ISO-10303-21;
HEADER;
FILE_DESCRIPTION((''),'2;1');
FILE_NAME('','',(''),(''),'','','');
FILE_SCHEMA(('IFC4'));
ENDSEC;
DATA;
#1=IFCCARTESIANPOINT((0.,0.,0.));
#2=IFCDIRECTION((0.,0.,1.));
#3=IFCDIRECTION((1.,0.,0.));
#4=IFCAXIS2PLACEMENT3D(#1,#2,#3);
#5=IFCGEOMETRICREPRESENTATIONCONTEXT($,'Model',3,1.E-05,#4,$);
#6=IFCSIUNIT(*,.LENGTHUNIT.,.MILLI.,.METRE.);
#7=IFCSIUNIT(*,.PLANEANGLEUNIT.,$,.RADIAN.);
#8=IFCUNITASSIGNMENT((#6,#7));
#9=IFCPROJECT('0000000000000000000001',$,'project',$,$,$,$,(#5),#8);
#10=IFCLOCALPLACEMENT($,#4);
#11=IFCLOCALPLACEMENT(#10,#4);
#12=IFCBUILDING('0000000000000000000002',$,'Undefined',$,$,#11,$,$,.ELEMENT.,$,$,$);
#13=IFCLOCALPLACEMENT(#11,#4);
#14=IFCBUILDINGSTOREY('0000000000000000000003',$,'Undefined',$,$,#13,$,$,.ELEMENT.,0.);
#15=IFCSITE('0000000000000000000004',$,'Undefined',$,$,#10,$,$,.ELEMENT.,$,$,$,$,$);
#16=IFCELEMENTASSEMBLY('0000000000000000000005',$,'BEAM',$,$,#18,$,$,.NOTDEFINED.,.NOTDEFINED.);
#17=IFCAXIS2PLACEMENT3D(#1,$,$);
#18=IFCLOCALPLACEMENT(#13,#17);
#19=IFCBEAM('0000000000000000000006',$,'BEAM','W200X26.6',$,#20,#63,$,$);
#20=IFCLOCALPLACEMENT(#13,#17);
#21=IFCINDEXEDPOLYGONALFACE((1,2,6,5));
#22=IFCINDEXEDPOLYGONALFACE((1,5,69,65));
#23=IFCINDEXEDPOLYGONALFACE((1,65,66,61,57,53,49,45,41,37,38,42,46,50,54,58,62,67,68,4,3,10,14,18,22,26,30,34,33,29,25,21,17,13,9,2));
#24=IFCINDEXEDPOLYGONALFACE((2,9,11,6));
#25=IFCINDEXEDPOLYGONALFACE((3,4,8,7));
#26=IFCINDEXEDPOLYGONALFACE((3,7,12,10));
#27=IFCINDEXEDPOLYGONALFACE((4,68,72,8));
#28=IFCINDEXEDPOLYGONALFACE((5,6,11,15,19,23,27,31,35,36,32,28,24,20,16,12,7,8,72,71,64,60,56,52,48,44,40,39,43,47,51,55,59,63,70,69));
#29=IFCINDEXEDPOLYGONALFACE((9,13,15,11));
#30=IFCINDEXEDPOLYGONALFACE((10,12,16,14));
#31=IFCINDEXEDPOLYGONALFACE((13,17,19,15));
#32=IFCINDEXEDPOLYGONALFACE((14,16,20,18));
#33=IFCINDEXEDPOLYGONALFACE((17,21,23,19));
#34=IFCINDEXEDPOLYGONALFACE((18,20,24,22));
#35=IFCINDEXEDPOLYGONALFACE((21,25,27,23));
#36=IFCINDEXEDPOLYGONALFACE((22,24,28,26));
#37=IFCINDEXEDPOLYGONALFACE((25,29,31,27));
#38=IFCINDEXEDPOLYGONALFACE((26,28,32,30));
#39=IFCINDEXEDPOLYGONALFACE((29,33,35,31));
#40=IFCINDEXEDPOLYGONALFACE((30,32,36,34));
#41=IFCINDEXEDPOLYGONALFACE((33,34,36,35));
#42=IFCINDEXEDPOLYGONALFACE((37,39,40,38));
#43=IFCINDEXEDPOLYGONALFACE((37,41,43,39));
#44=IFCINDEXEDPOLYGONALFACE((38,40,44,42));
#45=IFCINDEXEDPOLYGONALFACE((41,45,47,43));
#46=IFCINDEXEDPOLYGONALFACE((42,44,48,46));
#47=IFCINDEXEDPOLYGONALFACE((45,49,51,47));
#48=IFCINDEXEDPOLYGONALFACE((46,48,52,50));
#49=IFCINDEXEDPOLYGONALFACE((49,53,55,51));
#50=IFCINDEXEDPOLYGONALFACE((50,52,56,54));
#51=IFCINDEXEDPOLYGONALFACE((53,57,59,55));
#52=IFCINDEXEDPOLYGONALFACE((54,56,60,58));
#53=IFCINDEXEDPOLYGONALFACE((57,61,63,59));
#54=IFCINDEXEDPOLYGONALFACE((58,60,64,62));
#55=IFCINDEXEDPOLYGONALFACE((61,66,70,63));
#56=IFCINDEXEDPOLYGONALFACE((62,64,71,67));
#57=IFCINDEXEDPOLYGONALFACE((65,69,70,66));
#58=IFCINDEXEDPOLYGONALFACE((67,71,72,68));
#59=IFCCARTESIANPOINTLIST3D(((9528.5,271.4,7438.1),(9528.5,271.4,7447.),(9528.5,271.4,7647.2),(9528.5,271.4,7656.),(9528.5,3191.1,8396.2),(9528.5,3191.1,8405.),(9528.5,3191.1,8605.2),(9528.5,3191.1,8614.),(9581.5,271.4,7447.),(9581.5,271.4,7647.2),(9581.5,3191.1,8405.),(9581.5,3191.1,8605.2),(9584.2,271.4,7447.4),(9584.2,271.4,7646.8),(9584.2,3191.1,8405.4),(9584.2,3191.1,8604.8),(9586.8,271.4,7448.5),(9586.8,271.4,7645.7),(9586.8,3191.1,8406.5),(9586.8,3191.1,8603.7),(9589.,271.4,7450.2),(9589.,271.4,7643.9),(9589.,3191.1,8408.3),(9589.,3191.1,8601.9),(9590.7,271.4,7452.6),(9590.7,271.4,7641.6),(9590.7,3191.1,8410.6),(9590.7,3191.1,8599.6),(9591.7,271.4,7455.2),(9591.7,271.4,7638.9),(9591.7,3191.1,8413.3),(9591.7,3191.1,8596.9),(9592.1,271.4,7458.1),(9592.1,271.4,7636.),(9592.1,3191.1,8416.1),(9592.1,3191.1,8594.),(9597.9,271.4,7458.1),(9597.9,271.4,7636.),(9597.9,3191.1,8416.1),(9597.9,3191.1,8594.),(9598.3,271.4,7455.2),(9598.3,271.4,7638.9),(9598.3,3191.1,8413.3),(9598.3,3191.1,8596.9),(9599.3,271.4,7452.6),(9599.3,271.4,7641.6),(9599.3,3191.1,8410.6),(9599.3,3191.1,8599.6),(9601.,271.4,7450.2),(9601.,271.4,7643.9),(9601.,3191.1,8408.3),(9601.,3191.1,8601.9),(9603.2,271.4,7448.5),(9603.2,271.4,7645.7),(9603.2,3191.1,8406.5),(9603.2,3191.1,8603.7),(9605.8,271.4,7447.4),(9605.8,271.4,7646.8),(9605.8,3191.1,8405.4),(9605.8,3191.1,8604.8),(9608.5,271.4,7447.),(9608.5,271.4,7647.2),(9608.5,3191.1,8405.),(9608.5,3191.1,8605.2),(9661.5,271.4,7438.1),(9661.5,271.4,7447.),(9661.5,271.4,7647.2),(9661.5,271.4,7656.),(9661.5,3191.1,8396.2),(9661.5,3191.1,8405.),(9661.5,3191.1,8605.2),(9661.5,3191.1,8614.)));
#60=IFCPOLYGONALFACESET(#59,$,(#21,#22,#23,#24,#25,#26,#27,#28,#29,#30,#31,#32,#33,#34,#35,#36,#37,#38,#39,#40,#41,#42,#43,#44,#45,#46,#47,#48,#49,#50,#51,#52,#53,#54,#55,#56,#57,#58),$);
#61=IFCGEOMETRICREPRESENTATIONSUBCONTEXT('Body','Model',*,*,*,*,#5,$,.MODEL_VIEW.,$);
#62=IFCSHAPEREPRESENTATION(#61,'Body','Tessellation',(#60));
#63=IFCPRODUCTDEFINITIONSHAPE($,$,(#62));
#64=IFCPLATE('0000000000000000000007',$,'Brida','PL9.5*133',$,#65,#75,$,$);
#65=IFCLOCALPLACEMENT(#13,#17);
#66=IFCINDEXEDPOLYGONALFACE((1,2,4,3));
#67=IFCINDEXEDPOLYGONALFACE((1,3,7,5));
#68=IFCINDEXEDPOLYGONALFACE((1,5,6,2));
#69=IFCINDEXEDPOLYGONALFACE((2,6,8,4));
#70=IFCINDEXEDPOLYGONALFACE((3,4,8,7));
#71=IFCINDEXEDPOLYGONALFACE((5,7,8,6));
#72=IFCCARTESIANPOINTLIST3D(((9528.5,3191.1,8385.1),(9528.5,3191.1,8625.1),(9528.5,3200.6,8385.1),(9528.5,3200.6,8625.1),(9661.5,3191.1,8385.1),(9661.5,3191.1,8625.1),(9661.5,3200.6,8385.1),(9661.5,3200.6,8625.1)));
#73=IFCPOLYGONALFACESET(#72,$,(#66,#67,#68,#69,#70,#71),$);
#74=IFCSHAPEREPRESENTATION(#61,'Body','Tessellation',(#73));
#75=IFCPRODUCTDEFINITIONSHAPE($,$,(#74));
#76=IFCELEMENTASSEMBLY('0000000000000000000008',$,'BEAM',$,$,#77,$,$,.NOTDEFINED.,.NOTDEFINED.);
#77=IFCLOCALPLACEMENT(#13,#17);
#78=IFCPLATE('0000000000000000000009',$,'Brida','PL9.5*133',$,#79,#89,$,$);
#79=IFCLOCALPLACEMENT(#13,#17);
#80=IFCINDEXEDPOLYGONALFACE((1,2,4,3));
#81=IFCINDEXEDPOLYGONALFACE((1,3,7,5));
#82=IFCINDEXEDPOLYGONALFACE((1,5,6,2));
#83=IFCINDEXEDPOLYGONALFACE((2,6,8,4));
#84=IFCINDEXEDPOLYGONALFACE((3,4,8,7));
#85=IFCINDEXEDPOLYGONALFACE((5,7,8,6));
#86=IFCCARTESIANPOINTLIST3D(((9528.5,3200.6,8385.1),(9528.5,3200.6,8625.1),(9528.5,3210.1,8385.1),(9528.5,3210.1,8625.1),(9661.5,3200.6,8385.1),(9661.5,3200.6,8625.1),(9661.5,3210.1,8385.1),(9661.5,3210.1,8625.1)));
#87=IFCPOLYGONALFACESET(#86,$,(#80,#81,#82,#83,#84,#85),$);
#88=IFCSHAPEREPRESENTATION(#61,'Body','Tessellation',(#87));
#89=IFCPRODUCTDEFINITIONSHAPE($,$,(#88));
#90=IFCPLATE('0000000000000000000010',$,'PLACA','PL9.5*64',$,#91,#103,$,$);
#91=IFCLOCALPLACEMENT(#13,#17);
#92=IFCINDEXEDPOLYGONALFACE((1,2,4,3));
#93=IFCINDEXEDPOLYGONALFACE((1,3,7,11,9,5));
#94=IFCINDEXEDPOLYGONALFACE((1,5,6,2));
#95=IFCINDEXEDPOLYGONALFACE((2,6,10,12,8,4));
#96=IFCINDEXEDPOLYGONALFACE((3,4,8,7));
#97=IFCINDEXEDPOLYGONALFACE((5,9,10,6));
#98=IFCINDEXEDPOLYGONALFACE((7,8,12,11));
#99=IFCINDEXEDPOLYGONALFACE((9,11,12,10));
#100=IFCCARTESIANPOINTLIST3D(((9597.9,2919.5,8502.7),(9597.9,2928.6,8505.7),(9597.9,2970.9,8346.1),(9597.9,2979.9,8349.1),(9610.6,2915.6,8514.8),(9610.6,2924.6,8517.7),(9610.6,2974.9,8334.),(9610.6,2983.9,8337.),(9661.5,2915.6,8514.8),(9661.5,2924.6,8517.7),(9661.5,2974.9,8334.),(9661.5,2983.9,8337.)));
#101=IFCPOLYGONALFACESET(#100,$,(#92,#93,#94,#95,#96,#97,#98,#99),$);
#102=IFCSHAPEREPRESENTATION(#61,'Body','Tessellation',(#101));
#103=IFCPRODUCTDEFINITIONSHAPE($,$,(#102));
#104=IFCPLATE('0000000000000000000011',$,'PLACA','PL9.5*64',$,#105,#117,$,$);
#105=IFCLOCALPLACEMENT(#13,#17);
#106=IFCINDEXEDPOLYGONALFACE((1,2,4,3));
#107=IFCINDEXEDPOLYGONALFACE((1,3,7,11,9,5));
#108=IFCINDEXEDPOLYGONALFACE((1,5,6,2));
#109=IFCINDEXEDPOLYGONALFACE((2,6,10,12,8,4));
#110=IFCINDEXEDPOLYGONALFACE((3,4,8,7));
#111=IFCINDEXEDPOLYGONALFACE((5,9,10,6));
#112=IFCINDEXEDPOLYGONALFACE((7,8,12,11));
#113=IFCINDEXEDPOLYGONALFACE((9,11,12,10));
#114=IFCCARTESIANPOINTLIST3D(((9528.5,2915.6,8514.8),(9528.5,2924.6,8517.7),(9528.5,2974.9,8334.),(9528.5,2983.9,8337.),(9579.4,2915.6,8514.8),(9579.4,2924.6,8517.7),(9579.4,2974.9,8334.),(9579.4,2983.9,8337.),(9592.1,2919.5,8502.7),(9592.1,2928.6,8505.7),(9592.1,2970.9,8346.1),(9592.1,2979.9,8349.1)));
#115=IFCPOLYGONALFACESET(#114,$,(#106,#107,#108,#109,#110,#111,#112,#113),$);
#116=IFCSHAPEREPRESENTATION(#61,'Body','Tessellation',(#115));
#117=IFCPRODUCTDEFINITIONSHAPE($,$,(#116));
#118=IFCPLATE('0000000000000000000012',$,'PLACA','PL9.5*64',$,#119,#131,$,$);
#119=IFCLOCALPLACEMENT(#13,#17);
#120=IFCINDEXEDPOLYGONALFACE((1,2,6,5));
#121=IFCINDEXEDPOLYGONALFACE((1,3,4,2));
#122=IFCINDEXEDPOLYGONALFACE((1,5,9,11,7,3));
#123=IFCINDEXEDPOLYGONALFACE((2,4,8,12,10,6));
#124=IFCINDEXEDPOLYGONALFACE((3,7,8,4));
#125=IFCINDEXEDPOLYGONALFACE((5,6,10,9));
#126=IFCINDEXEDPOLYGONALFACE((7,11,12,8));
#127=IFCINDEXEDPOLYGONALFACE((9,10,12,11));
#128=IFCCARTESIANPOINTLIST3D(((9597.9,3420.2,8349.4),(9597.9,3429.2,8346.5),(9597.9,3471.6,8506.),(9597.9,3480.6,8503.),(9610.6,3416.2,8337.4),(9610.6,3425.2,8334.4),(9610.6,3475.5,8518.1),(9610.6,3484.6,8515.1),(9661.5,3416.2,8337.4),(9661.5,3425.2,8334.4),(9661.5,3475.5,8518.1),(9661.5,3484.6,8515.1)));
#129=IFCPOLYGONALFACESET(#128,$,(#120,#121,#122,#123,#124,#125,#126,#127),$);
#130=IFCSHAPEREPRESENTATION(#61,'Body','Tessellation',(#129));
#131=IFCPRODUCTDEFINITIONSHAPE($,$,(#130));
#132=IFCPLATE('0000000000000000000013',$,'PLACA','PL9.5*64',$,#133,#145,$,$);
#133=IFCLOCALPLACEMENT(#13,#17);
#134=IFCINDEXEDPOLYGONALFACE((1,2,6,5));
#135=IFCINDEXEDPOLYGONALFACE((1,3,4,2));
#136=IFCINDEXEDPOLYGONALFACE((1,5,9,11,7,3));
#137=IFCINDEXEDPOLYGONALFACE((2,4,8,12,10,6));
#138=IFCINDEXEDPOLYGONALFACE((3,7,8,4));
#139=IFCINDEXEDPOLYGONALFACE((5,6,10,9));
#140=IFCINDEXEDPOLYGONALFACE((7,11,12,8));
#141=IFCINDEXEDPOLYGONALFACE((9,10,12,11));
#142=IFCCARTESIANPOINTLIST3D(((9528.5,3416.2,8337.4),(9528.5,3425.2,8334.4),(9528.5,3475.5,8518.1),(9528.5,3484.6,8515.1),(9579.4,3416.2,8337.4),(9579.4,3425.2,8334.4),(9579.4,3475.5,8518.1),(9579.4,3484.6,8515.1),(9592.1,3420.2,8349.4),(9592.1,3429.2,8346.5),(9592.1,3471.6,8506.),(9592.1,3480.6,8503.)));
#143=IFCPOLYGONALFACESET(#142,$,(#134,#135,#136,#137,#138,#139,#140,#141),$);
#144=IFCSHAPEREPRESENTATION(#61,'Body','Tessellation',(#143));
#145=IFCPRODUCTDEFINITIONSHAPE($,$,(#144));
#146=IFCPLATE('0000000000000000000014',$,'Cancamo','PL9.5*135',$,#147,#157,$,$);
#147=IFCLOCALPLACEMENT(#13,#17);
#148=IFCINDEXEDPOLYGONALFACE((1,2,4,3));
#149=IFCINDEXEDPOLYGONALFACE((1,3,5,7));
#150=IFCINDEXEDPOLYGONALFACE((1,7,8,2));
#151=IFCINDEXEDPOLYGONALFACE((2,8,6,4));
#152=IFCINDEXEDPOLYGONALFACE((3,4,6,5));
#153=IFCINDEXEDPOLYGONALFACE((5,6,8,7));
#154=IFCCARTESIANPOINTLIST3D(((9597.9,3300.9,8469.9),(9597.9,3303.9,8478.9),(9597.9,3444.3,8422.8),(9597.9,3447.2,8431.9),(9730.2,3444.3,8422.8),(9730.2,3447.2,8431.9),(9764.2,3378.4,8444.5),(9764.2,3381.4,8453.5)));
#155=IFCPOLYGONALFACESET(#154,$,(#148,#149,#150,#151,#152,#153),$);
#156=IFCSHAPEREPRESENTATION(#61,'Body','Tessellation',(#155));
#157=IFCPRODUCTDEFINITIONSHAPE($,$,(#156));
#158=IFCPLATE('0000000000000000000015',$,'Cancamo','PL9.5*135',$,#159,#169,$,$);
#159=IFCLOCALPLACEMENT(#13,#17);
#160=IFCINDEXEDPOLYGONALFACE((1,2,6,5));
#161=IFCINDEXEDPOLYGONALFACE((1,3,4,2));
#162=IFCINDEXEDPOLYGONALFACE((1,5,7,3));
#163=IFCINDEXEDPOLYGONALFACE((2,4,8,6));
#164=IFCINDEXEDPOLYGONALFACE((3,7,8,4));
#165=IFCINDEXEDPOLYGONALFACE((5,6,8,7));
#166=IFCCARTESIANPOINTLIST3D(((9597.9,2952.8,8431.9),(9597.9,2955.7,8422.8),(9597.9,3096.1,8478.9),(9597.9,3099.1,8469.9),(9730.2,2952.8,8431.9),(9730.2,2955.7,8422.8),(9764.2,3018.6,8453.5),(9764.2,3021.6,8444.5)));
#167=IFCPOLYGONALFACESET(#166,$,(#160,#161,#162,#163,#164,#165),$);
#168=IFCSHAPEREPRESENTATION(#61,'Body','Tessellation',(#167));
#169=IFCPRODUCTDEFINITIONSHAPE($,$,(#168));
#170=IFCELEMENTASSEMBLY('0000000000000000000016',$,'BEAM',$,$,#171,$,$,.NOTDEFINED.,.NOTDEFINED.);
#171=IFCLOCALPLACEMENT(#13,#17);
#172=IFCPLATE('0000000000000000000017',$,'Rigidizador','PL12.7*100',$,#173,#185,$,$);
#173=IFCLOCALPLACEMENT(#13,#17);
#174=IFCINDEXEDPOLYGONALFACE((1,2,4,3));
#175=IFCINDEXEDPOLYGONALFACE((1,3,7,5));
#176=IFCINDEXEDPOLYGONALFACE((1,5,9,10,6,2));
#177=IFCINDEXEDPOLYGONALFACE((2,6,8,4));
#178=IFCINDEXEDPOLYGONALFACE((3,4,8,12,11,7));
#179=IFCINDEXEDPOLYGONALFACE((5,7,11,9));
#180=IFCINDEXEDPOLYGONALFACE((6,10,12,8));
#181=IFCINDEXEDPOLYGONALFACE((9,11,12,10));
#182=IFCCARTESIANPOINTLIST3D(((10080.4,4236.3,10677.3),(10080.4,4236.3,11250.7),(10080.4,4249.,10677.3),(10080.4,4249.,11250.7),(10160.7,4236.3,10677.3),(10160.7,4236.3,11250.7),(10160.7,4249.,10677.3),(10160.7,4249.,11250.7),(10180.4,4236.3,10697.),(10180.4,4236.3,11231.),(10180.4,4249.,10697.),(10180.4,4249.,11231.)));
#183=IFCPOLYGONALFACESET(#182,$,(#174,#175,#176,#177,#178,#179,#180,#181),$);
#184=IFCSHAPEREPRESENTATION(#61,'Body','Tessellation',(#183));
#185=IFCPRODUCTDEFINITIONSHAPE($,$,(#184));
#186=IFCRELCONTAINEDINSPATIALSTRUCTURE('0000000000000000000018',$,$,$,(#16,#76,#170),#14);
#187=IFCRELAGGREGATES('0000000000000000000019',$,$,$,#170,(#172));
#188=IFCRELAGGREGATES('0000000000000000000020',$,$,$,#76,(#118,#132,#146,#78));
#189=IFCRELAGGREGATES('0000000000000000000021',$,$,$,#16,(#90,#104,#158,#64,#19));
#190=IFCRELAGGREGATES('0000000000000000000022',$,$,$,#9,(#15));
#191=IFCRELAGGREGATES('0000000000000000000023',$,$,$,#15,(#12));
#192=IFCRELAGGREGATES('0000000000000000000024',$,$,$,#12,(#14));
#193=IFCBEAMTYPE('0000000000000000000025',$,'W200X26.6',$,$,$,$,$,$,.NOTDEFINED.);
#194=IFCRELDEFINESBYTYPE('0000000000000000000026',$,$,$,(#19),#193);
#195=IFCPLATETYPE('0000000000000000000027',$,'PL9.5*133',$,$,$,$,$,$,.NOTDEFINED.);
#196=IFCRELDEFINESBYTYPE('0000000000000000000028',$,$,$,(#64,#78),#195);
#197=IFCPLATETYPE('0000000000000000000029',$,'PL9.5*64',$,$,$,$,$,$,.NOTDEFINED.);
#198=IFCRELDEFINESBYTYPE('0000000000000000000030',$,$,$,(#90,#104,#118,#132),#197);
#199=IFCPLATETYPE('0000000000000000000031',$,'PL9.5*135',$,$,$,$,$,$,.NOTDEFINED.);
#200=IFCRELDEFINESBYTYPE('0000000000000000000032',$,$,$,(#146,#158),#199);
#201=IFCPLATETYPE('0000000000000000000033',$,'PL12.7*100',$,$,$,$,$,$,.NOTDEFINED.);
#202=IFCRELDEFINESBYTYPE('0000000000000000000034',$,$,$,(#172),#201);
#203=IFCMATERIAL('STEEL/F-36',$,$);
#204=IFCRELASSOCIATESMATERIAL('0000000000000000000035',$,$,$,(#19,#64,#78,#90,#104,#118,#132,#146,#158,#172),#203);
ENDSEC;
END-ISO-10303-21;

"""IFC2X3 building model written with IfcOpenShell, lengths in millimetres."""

from ifc_helpers import new_model, si_unit, frame, origin_with_axes, origin_2d_with_axis, place, context, subcontext, project, spatial, polyline, i_section, outline, extrude, clip, halfspace, material, type_object, element, aggregate, save


model = new_model("IFC2X3")

# Units and contexts
model_context = context("Model", 3, precision=1e-05, world=origin_with_axes())
body_context = subcontext(model_context, "Body", "Model", "MODEL_VIEW")
ifc_project = project(units=[si_unit("LENGTHUNIT", "METRE", prefix="MILLI"), si_unit("PLANEANGLEUNIT", "RADIAN")], contexts=[model_context])

# Site, building, storey
site_placement = place(None, origin_with_axes())
site = spatial("IfcSite", under=ifc_project, at=site_placement, Name="Undefined", CompositionType="ELEMENT")
building_placement = place(site_placement, origin_with_axes())
building = spatial("IfcBuilding", under=site, at=building_placement, Name="Undefined", CompositionType="ELEMENT")
storey_placement = place(building_placement, origin_with_axes())
storey = spatial("IfcBuildingStorey", under=building, at=storey_placement, Name="Undefined", CompositionType="ELEMENT", Elevation=0.0)

# Element assembly, beam, plate
assembly_1_placement = place(storey_placement, origin_with_axes())
assembly_1 = element("IfcElementAssembly", 1, at=assembly_1_placement, inside=storey, Name="BEAM", AssemblyPlace="NOTDEFINED", PredefinedType="NOTDEFINED")
ifc_material_1 = material(Name="STEEL/F-36")
beam_type_1 = type_object("IfcBeamType", Name="W200X26.6", PredefinedType="NOTDEFINED")
beam_1_placement = place(assembly_1_placement, frame((9595.0, 3232.7, 8518.7), z_axis=(0.0, -0.311771, 0.950157), x_axis=(0.0, -0.950157, -0.311771)))
beam_1 = element("IfcBeam", 2, at=beam_1_placement, type_object=beam_type_1, material=ifc_material_1, Name="BEAM", Description="W200X26.6", context=body_context, shape_type="Clipping", body=[
    clip(clip(extrude(i_section(OverallWidth=133.0, OverallDepth=207.0, WebThickness=5.8, FlangeThickness=8.4, FilletRadius=10.6, at=origin_2d_with_axis()), frame((3367.9, 0.0, 0.0), z_axis=(-1.0, 0.0, 0.0), x_axis=(0.0, -1.0, 0.0)), (0.0, 0.0, 1.0), 3392.7), halfspace(frame((3082.6, 0.0, 103.8), z_axis=(-0.950157, 0.0, -0.311771), x_axis=(0.311771, 0.0, -0.950157)), True)), halfspace(frame((8.8, 0.0, 106.5), z_axis=(-0.950152, 0.0, -0.311787), x_axis=(0.0, -1.0, 0.0)), False)),
])
plate_type_1 = type_object("IfcPlateType", Name="PL9.5*133", PredefinedType="NOTDEFINED")
plate_1_placement = place(assembly_1_placement, frame((9595.0, 3195.9, 8625.1), z_axis=(0.0, 1.0, -0.000017), x_axis=(0.0, -0.000017, -1.0)))
plate_1 = element("IfcPlate", 3, at=plate_1_placement, type_object=plate_type_1, material=ifc_material_1, Name="Brida", Description="PL9.5*133", context=body_context, shape_type="SweptSolid", body=[
    extrude(outline(polyline([(0.0, -66.5), (0.0, 66.5), (240.0, 66.5), (240.0, -66.5), (0.0, -66.5)])), frame((0.0, 0.0, -4.8), z_axis=(0.0, 0.0, 1.0), x_axis=(1.0, 0.0, 0.0)), (0.0, 0.0, 1.0), 9.5),
])

# Element assembly, plate
assembly_2_placement = place(storey_placement, origin_with_axes())
assembly_2 = element("IfcElementAssembly", 4, at=assembly_2_placement, inside=storey, Name="BEAM", AssemblyPlace="NOTDEFINED", PredefinedType="NOTDEFINED")
plate_2_placement = place(assembly_2_placement, frame((9595.0, 3205.4, 8625.1), z_axis=(0.0, 1.0, -0.000017), x_axis=(0.0, -0.000017, -1.0)))
plate_2 = element("IfcPlate", 5, at=plate_2_placement, type_object=plate_type_1, material=ifc_material_1, Name="Brida", Description="PL9.5*133", context=body_context, shape_type="SweptSolid", body=[
    extrude(outline(polyline([(0.0, -66.5), (0.0, 66.5), (240.0, 66.5), (240.0, -66.5), (0.0, -66.5)])), frame((0.0, 0.0, -4.8), z_axis=(0.0, 0.0, 1.0), x_axis=(1.0, 0.0, 0.0)), (0.0, 0.0, 1.0), 9.5),
])

# Plates
plate_type_2 = type_object("IfcPlateType", Name="PL9.5*64", PredefinedType="NOTDEFINED")
plate_3_placement = place(assembly_1_placement, frame((9597.9, 2920.1, 8516.2), z_axis=(0.0, 0.950157, 0.311771), x_axis=(1.0, 0.0, 0.0)))
plate_3 = element("IfcPlate", 6, at=plate_3_placement, type_object=plate_type_2, material=ifc_material_1, Name="PLACA", Description="PL9.5*64", context=body_context, shape_type="SweptSolid", body=[
    extrude(outline(polyline([(0.0, 12.7), (12.7, 0.0), (63.6, 0.0), (63.6, 190.2), (12.7, 190.2), (0.0, 177.5), (0.0, 12.7)])), frame((0.0, 0.0, -4.8), z_axis=(0.0, 0.0, 1.0), x_axis=(1.0, 0.0, 0.0)), (0.0, 0.0, 1.0), 9.5),
])
plate_4_placement = place(assembly_1_placement, frame((9528.5, 2920.1, 8516.2), z_axis=(0.0, 0.950157, 0.311771), x_axis=(1.0, 0.0, 0.0)))
plate_4 = element("IfcPlate", 7, at=plate_4_placement, type_object=plate_type_2, material=ifc_material_1, Name="PLACA", Description="PL9.5*64", context=body_context, shape_type="SweptSolid", body=[
    extrude(outline(polyline([(0.0, 0.0), (50.9, 0.0), (63.6, 12.7), (63.6, 177.5), (50.9, 190.2), (0.0, 190.2), (0.0, 0.0)])), frame((0.0, 0.0, -4.8), z_axis=(0.0, 0.0, 1.0), x_axis=(1.0, 0.0, 0.0)), (0.0, 0.0, 1.0), 9.5),
])
plate_5_placement = place(assembly_2_placement, frame((9597.9, 3480.0, 8516.6), z_axis=(0.0, 0.950147, -0.311803), x_axis=(1.0, 0.0, 0.0)))
plate_5 = element("IfcPlate", 8, at=plate_5_placement, type_object=plate_type_2, material=ifc_material_1, Name="PLACA", Description="PL9.5*64", context=body_context, shape_type="SweptSolid", body=[
    extrude(outline(polyline([(0.0, 12.7), (12.7, 0.0), (63.6, 0.0), (63.6, 190.2), (12.7, 190.2), (0.0, 177.5), (0.0, 12.7)])), frame((0.0, 0.0, -4.8), z_axis=(0.0, 0.0, 1.0), x_axis=(1.0, 0.0, 0.0)), (0.0, 0.0, 1.0), 9.5),
])
plate_6_placement = place(assembly_2_placement, frame((9528.5, 3480.0, 8516.6), z_axis=(0.0, 0.950147, -0.311803), x_axis=(1.0, 0.0, 0.0)))
plate_6 = element("IfcPlate", 9, at=plate_6_placement, type_object=plate_type_2, material=ifc_material_1, Name="PLACA", Description="PL9.5*64", context=body_context, shape_type="SweptSolid", body=[
    extrude(outline(polyline([(0.0, 0.0), (50.9, 0.0), (63.6, 12.7), (63.6, 177.5), (50.9, 190.2), (0.0, 190.2), (0.0, 0.0)])), frame((0.0, 0.0, -4.8), z_axis=(0.0, 0.0, 1.0), x_axis=(1.0, 0.0, 0.0)), (0.0, 0.0, 1.0), 9.5),
])
plate_type_3 = type_object("IfcPlateType", Name="PL9.5*135", PredefinedType="NOTDEFINED")
plate_7_placement = place(assembly_2_placement, frame((9597.9, 3445.8, 8427.4), z_axis=(-0.000016, 0.311803, 0.950147), x_axis=(0.0, -0.950147, 0.311803)))
plate_7 = element("IfcPlate", 10, at=plate_7_placement, type_object=plate_type_3, material=ifc_material_1, Name="Cancamo", Description="PL9.5*135", context=body_context, shape_type="SweptSolid", body=[
    extrude(outline(polyline([(0.0, 0.0), (150.9, 0.0), (69.3, 166.3), (0.0, 132.3), (0.0, 0.0)])), frame((0.0, 0.0, -4.8), z_axis=(0.0, 0.0, 1.0), x_axis=(1.0, 0.0, 0.0)), (0.0, 0.0, 1.0), 9.5),
])
plate_8_placement = place(assembly_1_placement, frame((9597.9, 3097.6, 8474.4), z_axis=(0.0, -0.311771, 0.950157), x_axis=(0.0, -0.950157, -0.311771)))
plate_8 = element("IfcPlate", 11, at=plate_8_placement, type_object=plate_type_3, material=ifc_material_1, Name="Cancamo", Description="PL9.5*135", context=body_context, shape_type="SweptSolid", body=[
    extrude(outline(polyline([(0.0, 0.0), (150.9, 0.0), (150.9, 132.3), (81.5, 166.3), (0.0, 0.0)])), frame((0.0, 0.0, -4.8), z_axis=(0.0, 0.0, 1.0), x_axis=(1.0, 0.0, 0.0)), (0.0, 0.0, 1.0), 9.5),
])

# Element assembly, plate
assembly_3_placement = place(storey_placement, origin_with_axes())
assembly_3 = element("IfcElementAssembly", 12, at=assembly_3_placement, inside=storey, Name="BEAM", AssemblyPlace="NOTDEFINED", PredefinedType="NOTDEFINED")
plate_type_4 = type_object("IfcPlateType", Name="PL12.7*100", PredefinedType="NOTDEFINED")
plate_9_placement = place(assembly_3_placement, frame((10180.4, 4242.7, 10677.3), z_axis=(0.0, 1.0, 0.0), x_axis=(-1.0, 0.0, 0.0)))
plate_9 = element("IfcPlate", 13, at=plate_9_placement, type_object=plate_type_4, material=ifc_material_1, Name="Rigidizador", Description="PL12.7*100", context=body_context, shape_type="SweptSolid", body=[
    extrude(outline(polyline([(0.0, 19.7), (19.7, 0.0), (100.0, 0.0), (100.0, 573.4), (19.7, 573.4), (0.0, 553.7), (0.0, 19.7)])), frame((0.0, 0.0, -6.3), z_axis=(0.0, 0.0, 1.0), x_axis=(1.0, 0.0, 0.0)), (0.0, 0.0, 1.0), 12.7),
])
aggregate(assembly_3, [plate_9])

aggregate(assembly_2, [plate_5, plate_6, plate_7, plate_2])

aggregate(assembly_1, [plate_3, plate_4, plate_8, plate_1, beam_1])

save(model, "model.ifc")
